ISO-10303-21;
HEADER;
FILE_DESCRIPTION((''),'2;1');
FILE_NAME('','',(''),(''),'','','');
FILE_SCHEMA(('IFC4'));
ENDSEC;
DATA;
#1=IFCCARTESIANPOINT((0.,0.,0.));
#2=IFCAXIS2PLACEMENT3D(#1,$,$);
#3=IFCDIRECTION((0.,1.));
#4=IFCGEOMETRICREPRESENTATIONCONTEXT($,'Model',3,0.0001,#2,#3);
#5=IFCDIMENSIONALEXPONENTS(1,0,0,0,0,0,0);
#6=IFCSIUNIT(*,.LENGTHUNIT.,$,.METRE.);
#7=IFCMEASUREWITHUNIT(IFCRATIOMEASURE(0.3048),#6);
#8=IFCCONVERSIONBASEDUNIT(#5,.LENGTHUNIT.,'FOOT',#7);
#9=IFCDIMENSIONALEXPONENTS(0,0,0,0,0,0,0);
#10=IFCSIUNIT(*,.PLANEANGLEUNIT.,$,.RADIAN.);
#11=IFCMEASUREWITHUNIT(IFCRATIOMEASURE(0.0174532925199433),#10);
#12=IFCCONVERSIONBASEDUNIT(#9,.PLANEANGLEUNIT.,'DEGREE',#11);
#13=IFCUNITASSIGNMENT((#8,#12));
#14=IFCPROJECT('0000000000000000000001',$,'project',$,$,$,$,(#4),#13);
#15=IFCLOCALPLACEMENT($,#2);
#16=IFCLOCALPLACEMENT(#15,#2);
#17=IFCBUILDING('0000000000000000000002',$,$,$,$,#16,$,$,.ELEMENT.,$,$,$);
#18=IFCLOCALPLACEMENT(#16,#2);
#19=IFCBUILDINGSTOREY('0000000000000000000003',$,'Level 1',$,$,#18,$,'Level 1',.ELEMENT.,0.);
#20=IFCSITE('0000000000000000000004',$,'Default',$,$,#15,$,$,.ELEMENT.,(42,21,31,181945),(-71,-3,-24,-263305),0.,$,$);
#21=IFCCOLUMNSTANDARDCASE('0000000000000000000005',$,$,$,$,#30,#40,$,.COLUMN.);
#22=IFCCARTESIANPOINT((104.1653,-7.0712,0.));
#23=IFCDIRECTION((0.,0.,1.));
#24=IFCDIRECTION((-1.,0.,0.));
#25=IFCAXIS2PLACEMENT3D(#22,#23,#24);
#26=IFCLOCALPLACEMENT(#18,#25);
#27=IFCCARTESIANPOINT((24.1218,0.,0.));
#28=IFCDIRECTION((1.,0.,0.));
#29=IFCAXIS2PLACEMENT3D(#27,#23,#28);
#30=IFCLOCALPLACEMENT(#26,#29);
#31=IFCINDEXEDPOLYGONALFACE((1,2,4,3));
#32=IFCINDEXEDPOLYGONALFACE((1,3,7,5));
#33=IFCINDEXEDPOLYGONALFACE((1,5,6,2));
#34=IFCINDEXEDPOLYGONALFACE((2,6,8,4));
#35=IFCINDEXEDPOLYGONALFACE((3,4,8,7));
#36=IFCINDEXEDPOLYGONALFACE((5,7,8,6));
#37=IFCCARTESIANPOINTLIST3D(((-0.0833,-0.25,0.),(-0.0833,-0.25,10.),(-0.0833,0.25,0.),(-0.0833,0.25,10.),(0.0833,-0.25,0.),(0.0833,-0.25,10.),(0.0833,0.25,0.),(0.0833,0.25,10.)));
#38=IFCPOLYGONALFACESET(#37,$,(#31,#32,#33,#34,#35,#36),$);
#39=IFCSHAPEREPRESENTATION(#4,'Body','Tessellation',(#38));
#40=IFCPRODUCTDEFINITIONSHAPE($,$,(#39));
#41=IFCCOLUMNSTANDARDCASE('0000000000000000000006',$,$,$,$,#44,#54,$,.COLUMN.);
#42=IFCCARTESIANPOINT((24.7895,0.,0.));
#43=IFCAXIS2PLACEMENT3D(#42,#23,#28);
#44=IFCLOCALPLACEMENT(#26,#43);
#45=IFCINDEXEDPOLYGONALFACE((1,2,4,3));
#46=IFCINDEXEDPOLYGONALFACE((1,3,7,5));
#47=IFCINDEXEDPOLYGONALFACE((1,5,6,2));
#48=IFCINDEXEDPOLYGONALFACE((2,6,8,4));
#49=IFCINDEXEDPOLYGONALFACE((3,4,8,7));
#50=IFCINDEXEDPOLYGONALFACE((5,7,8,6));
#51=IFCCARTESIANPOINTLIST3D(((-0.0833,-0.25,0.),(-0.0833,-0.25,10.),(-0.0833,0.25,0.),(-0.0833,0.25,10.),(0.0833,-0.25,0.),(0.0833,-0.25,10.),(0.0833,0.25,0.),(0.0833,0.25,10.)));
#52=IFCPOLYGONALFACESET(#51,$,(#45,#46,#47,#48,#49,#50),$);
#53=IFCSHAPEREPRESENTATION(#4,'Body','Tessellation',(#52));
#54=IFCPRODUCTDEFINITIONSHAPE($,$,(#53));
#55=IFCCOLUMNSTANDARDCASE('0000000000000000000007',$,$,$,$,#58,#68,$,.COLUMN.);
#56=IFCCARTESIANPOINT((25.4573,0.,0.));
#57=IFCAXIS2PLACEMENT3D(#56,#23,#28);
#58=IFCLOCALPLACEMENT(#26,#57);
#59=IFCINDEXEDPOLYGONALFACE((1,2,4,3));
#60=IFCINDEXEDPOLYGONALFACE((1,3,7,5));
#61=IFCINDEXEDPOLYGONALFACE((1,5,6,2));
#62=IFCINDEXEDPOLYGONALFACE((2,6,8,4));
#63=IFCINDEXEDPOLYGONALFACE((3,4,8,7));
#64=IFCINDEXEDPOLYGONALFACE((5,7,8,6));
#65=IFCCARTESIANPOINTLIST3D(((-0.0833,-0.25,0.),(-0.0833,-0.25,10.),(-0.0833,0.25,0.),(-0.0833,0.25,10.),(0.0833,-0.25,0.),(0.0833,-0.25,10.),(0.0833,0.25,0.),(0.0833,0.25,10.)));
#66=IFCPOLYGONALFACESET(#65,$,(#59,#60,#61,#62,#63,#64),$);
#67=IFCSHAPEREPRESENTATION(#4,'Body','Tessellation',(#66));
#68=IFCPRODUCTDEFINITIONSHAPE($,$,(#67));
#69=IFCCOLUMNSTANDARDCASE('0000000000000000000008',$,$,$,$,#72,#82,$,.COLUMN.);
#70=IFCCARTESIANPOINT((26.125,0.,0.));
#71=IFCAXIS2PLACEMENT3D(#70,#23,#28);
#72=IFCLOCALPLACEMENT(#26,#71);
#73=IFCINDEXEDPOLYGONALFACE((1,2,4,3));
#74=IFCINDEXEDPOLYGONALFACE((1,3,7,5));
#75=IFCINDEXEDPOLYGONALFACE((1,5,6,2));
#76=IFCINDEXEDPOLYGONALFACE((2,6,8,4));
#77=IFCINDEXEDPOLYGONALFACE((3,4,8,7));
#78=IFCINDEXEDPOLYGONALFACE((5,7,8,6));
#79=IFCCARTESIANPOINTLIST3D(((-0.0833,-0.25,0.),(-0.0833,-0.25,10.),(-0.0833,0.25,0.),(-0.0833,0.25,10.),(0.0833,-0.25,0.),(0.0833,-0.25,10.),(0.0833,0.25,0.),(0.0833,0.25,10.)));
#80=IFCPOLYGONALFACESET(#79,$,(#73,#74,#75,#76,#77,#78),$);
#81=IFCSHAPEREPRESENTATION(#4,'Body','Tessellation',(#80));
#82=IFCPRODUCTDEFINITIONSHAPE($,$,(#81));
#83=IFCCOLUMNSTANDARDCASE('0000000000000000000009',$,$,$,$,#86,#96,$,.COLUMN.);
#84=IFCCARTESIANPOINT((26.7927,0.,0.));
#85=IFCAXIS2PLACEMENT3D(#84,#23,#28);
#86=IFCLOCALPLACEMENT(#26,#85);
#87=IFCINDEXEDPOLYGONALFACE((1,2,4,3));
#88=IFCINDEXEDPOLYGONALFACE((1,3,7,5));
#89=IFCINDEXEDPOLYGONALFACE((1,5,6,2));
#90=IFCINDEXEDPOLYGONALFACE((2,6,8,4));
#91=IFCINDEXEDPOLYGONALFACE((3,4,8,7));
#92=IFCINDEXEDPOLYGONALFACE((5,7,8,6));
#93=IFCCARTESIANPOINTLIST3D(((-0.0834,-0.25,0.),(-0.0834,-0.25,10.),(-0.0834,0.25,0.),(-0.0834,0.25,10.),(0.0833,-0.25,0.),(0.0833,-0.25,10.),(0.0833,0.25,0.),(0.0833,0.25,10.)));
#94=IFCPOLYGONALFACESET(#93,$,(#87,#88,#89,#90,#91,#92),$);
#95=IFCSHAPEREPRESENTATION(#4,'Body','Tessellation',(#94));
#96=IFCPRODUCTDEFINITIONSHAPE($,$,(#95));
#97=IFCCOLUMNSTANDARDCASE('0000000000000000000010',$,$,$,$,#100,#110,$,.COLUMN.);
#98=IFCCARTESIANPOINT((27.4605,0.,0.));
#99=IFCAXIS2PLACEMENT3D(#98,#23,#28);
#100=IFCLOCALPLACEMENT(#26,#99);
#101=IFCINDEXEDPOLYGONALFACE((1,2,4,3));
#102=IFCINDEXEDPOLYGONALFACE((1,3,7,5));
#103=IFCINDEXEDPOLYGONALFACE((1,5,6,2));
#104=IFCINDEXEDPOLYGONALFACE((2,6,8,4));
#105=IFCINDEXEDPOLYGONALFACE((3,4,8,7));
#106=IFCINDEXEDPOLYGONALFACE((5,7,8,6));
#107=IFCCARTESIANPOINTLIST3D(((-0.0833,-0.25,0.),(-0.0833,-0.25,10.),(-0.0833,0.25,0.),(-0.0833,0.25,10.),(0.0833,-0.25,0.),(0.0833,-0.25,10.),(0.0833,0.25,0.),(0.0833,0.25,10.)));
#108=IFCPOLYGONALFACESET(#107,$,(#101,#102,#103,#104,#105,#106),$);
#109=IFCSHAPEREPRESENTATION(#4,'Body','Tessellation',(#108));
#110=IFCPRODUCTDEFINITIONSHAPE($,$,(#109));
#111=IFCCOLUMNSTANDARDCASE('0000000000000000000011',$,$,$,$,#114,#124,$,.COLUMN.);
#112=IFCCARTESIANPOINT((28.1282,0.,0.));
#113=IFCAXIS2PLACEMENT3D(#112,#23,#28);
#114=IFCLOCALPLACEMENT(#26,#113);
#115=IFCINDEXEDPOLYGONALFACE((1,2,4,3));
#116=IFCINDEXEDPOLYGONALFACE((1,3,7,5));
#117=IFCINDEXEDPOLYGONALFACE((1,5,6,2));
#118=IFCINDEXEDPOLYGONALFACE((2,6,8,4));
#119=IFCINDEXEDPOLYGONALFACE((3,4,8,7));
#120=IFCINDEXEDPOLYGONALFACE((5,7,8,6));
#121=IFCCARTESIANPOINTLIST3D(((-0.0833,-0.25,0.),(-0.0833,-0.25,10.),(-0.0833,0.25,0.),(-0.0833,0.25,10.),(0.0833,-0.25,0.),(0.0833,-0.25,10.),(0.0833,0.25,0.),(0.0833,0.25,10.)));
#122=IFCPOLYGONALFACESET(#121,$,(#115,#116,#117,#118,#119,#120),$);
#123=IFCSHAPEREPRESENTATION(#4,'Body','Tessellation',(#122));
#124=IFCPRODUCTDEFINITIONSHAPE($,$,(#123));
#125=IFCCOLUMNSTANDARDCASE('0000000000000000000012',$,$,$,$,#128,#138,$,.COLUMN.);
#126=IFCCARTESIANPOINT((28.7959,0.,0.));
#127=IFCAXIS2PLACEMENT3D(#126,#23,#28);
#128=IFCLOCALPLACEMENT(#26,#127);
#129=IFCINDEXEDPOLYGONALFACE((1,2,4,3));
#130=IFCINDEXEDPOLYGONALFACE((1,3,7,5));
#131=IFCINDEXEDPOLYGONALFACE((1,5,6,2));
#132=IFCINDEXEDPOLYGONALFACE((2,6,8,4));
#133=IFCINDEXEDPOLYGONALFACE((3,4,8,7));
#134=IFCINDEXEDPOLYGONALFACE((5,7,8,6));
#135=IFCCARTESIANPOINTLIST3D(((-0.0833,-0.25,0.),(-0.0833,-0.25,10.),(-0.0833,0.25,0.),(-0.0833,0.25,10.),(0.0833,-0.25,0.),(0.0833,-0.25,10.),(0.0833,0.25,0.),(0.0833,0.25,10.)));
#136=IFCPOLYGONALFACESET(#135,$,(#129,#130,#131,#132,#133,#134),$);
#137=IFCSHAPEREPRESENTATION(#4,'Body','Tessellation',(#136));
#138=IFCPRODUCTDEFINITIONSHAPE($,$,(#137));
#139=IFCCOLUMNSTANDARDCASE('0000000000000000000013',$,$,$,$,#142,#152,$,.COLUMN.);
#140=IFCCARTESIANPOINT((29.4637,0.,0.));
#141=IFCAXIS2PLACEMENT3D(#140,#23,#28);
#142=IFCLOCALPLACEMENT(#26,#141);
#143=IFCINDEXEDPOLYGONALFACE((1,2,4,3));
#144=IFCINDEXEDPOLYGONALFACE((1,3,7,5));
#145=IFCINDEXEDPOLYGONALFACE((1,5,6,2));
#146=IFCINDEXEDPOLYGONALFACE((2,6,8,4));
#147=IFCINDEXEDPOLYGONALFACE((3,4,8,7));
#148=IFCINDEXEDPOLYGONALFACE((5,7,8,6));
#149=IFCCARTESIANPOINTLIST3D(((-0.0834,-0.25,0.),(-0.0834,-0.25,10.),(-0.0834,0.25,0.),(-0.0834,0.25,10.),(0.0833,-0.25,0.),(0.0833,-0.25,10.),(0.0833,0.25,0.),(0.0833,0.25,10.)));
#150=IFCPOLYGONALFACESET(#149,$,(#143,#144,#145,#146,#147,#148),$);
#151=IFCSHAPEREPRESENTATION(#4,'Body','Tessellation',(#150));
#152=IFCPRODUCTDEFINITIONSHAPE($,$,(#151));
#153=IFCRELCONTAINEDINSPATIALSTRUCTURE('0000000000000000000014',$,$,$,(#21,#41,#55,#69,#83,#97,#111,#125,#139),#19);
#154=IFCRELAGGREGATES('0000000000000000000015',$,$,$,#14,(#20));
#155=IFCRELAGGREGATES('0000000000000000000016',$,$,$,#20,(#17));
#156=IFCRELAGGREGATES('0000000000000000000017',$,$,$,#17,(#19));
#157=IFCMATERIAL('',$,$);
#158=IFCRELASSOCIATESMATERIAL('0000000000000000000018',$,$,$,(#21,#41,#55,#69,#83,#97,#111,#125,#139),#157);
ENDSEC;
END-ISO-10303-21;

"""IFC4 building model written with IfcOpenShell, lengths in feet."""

from ifc_helpers import new_model, entity, si_unit, converted_unit, direction, frame, origin, place, context, project, spatial, rectangle, extrude, material, element, save


model = new_model("IFC4")

# Units and contexts
model_context = context("Model", 3, precision=0.0001, world=origin(), true_north=direction((0.0, 1.0)))
ifc_project = project(units=[converted_unit("LENGTHUNIT", "FOOT", entity("IfcRatioMeasure", 0.3048), si_unit("LENGTHUNIT", "METRE"), dimensions=[1, 0, 0, 0, 0, 0, 0]), converted_unit("PLANEANGLEUNIT", "DEGREE", entity("IfcRatioMeasure", 0.0174532925199433), si_unit("PLANEANGLEUNIT", "RADIAN"), dimensions=[0, 0, 0, 0, 0, 0, 0])], contexts=[model_context])

# Site, building, storey
site_placement = place(None, origin())
site = spatial("IfcSite", under=ifc_project, at=site_placement, Name="Default", CompositionType="ELEMENT", RefLatitude=(42, 21, 31, 181945), RefLongitude=(-71, -3, -24, -263305), RefElevation=0.0)
building_placement = place(site_placement, origin())
building = spatial("IfcBuilding", under=site, at=building_placement, CompositionType="ELEMENT")
storey_placement = place(building_placement, origin())
storey = spatial("IfcBuildingStorey", under=building, at=storey_placement, Name="Level 1", LongName="Level 1", CompositionType="ELEMENT", Elevation=0.0)

# Columns
ifc_material = material(Name="")
placement = place(storey_placement, frame((104.1653, -7.0712, 0.0), z_axis=(0.0, 0.0, 1.0), x_axis=(-1.0, 0.0, 0.0)))
for number, where, z_axis, x_axis in (
    (1, (24.1218, 0.0, 0.0), (0.0, 0.0, 1.0), (1.0, 0.0, 0.0)),
    (2, (24.7895, 0.0, 0.0), (0.0, 0.0, 1.0), (1.0, 0.0, 0.0)),
    (3, (25.4573, 0.0, 0.0), (0.0, 0.0, 1.0), (1.0, 0.0, 0.0)),
    (4, (26.125, 0.0, 0.0), (0.0, 0.0, 1.0), (1.0, 0.0, 0.0)),
    (5, (26.7927, 0.0, 0.0), (0.0, 0.0, 1.0), (1.0, 0.0, 0.0)),
    (6, (27.4605, 0.0, 0.0), (0.0, 0.0, 1.0), (1.0, 0.0, 0.0)),
    (7, (28.1282, 0.0, 0.0), (0.0, 0.0, 1.0), (1.0, 0.0, 0.0)),
    (8, (28.7959, 0.0, 0.0), (0.0, 0.0, 1.0), (1.0, 0.0, 0.0)),
    (9, (29.4637, 0.0, 0.0), (0.0, 0.0, 1.0), (1.0, 0.0, 0.0)),
):
    element("IfcColumnStandardCase", number, at=place(placement, frame(where, z_axis=z_axis, x_axis=x_axis)), inside=storey, material=ifc_material, PredefinedType="COLUMN", context=model_context, shape_type="SweptSolid", body=[
        extrude(rectangle(XDim=0.1667, YDim=0.5), origin(), (0.0, 0.0, 1.0), 10.0),
    ])

save(model, "model.ifc")
